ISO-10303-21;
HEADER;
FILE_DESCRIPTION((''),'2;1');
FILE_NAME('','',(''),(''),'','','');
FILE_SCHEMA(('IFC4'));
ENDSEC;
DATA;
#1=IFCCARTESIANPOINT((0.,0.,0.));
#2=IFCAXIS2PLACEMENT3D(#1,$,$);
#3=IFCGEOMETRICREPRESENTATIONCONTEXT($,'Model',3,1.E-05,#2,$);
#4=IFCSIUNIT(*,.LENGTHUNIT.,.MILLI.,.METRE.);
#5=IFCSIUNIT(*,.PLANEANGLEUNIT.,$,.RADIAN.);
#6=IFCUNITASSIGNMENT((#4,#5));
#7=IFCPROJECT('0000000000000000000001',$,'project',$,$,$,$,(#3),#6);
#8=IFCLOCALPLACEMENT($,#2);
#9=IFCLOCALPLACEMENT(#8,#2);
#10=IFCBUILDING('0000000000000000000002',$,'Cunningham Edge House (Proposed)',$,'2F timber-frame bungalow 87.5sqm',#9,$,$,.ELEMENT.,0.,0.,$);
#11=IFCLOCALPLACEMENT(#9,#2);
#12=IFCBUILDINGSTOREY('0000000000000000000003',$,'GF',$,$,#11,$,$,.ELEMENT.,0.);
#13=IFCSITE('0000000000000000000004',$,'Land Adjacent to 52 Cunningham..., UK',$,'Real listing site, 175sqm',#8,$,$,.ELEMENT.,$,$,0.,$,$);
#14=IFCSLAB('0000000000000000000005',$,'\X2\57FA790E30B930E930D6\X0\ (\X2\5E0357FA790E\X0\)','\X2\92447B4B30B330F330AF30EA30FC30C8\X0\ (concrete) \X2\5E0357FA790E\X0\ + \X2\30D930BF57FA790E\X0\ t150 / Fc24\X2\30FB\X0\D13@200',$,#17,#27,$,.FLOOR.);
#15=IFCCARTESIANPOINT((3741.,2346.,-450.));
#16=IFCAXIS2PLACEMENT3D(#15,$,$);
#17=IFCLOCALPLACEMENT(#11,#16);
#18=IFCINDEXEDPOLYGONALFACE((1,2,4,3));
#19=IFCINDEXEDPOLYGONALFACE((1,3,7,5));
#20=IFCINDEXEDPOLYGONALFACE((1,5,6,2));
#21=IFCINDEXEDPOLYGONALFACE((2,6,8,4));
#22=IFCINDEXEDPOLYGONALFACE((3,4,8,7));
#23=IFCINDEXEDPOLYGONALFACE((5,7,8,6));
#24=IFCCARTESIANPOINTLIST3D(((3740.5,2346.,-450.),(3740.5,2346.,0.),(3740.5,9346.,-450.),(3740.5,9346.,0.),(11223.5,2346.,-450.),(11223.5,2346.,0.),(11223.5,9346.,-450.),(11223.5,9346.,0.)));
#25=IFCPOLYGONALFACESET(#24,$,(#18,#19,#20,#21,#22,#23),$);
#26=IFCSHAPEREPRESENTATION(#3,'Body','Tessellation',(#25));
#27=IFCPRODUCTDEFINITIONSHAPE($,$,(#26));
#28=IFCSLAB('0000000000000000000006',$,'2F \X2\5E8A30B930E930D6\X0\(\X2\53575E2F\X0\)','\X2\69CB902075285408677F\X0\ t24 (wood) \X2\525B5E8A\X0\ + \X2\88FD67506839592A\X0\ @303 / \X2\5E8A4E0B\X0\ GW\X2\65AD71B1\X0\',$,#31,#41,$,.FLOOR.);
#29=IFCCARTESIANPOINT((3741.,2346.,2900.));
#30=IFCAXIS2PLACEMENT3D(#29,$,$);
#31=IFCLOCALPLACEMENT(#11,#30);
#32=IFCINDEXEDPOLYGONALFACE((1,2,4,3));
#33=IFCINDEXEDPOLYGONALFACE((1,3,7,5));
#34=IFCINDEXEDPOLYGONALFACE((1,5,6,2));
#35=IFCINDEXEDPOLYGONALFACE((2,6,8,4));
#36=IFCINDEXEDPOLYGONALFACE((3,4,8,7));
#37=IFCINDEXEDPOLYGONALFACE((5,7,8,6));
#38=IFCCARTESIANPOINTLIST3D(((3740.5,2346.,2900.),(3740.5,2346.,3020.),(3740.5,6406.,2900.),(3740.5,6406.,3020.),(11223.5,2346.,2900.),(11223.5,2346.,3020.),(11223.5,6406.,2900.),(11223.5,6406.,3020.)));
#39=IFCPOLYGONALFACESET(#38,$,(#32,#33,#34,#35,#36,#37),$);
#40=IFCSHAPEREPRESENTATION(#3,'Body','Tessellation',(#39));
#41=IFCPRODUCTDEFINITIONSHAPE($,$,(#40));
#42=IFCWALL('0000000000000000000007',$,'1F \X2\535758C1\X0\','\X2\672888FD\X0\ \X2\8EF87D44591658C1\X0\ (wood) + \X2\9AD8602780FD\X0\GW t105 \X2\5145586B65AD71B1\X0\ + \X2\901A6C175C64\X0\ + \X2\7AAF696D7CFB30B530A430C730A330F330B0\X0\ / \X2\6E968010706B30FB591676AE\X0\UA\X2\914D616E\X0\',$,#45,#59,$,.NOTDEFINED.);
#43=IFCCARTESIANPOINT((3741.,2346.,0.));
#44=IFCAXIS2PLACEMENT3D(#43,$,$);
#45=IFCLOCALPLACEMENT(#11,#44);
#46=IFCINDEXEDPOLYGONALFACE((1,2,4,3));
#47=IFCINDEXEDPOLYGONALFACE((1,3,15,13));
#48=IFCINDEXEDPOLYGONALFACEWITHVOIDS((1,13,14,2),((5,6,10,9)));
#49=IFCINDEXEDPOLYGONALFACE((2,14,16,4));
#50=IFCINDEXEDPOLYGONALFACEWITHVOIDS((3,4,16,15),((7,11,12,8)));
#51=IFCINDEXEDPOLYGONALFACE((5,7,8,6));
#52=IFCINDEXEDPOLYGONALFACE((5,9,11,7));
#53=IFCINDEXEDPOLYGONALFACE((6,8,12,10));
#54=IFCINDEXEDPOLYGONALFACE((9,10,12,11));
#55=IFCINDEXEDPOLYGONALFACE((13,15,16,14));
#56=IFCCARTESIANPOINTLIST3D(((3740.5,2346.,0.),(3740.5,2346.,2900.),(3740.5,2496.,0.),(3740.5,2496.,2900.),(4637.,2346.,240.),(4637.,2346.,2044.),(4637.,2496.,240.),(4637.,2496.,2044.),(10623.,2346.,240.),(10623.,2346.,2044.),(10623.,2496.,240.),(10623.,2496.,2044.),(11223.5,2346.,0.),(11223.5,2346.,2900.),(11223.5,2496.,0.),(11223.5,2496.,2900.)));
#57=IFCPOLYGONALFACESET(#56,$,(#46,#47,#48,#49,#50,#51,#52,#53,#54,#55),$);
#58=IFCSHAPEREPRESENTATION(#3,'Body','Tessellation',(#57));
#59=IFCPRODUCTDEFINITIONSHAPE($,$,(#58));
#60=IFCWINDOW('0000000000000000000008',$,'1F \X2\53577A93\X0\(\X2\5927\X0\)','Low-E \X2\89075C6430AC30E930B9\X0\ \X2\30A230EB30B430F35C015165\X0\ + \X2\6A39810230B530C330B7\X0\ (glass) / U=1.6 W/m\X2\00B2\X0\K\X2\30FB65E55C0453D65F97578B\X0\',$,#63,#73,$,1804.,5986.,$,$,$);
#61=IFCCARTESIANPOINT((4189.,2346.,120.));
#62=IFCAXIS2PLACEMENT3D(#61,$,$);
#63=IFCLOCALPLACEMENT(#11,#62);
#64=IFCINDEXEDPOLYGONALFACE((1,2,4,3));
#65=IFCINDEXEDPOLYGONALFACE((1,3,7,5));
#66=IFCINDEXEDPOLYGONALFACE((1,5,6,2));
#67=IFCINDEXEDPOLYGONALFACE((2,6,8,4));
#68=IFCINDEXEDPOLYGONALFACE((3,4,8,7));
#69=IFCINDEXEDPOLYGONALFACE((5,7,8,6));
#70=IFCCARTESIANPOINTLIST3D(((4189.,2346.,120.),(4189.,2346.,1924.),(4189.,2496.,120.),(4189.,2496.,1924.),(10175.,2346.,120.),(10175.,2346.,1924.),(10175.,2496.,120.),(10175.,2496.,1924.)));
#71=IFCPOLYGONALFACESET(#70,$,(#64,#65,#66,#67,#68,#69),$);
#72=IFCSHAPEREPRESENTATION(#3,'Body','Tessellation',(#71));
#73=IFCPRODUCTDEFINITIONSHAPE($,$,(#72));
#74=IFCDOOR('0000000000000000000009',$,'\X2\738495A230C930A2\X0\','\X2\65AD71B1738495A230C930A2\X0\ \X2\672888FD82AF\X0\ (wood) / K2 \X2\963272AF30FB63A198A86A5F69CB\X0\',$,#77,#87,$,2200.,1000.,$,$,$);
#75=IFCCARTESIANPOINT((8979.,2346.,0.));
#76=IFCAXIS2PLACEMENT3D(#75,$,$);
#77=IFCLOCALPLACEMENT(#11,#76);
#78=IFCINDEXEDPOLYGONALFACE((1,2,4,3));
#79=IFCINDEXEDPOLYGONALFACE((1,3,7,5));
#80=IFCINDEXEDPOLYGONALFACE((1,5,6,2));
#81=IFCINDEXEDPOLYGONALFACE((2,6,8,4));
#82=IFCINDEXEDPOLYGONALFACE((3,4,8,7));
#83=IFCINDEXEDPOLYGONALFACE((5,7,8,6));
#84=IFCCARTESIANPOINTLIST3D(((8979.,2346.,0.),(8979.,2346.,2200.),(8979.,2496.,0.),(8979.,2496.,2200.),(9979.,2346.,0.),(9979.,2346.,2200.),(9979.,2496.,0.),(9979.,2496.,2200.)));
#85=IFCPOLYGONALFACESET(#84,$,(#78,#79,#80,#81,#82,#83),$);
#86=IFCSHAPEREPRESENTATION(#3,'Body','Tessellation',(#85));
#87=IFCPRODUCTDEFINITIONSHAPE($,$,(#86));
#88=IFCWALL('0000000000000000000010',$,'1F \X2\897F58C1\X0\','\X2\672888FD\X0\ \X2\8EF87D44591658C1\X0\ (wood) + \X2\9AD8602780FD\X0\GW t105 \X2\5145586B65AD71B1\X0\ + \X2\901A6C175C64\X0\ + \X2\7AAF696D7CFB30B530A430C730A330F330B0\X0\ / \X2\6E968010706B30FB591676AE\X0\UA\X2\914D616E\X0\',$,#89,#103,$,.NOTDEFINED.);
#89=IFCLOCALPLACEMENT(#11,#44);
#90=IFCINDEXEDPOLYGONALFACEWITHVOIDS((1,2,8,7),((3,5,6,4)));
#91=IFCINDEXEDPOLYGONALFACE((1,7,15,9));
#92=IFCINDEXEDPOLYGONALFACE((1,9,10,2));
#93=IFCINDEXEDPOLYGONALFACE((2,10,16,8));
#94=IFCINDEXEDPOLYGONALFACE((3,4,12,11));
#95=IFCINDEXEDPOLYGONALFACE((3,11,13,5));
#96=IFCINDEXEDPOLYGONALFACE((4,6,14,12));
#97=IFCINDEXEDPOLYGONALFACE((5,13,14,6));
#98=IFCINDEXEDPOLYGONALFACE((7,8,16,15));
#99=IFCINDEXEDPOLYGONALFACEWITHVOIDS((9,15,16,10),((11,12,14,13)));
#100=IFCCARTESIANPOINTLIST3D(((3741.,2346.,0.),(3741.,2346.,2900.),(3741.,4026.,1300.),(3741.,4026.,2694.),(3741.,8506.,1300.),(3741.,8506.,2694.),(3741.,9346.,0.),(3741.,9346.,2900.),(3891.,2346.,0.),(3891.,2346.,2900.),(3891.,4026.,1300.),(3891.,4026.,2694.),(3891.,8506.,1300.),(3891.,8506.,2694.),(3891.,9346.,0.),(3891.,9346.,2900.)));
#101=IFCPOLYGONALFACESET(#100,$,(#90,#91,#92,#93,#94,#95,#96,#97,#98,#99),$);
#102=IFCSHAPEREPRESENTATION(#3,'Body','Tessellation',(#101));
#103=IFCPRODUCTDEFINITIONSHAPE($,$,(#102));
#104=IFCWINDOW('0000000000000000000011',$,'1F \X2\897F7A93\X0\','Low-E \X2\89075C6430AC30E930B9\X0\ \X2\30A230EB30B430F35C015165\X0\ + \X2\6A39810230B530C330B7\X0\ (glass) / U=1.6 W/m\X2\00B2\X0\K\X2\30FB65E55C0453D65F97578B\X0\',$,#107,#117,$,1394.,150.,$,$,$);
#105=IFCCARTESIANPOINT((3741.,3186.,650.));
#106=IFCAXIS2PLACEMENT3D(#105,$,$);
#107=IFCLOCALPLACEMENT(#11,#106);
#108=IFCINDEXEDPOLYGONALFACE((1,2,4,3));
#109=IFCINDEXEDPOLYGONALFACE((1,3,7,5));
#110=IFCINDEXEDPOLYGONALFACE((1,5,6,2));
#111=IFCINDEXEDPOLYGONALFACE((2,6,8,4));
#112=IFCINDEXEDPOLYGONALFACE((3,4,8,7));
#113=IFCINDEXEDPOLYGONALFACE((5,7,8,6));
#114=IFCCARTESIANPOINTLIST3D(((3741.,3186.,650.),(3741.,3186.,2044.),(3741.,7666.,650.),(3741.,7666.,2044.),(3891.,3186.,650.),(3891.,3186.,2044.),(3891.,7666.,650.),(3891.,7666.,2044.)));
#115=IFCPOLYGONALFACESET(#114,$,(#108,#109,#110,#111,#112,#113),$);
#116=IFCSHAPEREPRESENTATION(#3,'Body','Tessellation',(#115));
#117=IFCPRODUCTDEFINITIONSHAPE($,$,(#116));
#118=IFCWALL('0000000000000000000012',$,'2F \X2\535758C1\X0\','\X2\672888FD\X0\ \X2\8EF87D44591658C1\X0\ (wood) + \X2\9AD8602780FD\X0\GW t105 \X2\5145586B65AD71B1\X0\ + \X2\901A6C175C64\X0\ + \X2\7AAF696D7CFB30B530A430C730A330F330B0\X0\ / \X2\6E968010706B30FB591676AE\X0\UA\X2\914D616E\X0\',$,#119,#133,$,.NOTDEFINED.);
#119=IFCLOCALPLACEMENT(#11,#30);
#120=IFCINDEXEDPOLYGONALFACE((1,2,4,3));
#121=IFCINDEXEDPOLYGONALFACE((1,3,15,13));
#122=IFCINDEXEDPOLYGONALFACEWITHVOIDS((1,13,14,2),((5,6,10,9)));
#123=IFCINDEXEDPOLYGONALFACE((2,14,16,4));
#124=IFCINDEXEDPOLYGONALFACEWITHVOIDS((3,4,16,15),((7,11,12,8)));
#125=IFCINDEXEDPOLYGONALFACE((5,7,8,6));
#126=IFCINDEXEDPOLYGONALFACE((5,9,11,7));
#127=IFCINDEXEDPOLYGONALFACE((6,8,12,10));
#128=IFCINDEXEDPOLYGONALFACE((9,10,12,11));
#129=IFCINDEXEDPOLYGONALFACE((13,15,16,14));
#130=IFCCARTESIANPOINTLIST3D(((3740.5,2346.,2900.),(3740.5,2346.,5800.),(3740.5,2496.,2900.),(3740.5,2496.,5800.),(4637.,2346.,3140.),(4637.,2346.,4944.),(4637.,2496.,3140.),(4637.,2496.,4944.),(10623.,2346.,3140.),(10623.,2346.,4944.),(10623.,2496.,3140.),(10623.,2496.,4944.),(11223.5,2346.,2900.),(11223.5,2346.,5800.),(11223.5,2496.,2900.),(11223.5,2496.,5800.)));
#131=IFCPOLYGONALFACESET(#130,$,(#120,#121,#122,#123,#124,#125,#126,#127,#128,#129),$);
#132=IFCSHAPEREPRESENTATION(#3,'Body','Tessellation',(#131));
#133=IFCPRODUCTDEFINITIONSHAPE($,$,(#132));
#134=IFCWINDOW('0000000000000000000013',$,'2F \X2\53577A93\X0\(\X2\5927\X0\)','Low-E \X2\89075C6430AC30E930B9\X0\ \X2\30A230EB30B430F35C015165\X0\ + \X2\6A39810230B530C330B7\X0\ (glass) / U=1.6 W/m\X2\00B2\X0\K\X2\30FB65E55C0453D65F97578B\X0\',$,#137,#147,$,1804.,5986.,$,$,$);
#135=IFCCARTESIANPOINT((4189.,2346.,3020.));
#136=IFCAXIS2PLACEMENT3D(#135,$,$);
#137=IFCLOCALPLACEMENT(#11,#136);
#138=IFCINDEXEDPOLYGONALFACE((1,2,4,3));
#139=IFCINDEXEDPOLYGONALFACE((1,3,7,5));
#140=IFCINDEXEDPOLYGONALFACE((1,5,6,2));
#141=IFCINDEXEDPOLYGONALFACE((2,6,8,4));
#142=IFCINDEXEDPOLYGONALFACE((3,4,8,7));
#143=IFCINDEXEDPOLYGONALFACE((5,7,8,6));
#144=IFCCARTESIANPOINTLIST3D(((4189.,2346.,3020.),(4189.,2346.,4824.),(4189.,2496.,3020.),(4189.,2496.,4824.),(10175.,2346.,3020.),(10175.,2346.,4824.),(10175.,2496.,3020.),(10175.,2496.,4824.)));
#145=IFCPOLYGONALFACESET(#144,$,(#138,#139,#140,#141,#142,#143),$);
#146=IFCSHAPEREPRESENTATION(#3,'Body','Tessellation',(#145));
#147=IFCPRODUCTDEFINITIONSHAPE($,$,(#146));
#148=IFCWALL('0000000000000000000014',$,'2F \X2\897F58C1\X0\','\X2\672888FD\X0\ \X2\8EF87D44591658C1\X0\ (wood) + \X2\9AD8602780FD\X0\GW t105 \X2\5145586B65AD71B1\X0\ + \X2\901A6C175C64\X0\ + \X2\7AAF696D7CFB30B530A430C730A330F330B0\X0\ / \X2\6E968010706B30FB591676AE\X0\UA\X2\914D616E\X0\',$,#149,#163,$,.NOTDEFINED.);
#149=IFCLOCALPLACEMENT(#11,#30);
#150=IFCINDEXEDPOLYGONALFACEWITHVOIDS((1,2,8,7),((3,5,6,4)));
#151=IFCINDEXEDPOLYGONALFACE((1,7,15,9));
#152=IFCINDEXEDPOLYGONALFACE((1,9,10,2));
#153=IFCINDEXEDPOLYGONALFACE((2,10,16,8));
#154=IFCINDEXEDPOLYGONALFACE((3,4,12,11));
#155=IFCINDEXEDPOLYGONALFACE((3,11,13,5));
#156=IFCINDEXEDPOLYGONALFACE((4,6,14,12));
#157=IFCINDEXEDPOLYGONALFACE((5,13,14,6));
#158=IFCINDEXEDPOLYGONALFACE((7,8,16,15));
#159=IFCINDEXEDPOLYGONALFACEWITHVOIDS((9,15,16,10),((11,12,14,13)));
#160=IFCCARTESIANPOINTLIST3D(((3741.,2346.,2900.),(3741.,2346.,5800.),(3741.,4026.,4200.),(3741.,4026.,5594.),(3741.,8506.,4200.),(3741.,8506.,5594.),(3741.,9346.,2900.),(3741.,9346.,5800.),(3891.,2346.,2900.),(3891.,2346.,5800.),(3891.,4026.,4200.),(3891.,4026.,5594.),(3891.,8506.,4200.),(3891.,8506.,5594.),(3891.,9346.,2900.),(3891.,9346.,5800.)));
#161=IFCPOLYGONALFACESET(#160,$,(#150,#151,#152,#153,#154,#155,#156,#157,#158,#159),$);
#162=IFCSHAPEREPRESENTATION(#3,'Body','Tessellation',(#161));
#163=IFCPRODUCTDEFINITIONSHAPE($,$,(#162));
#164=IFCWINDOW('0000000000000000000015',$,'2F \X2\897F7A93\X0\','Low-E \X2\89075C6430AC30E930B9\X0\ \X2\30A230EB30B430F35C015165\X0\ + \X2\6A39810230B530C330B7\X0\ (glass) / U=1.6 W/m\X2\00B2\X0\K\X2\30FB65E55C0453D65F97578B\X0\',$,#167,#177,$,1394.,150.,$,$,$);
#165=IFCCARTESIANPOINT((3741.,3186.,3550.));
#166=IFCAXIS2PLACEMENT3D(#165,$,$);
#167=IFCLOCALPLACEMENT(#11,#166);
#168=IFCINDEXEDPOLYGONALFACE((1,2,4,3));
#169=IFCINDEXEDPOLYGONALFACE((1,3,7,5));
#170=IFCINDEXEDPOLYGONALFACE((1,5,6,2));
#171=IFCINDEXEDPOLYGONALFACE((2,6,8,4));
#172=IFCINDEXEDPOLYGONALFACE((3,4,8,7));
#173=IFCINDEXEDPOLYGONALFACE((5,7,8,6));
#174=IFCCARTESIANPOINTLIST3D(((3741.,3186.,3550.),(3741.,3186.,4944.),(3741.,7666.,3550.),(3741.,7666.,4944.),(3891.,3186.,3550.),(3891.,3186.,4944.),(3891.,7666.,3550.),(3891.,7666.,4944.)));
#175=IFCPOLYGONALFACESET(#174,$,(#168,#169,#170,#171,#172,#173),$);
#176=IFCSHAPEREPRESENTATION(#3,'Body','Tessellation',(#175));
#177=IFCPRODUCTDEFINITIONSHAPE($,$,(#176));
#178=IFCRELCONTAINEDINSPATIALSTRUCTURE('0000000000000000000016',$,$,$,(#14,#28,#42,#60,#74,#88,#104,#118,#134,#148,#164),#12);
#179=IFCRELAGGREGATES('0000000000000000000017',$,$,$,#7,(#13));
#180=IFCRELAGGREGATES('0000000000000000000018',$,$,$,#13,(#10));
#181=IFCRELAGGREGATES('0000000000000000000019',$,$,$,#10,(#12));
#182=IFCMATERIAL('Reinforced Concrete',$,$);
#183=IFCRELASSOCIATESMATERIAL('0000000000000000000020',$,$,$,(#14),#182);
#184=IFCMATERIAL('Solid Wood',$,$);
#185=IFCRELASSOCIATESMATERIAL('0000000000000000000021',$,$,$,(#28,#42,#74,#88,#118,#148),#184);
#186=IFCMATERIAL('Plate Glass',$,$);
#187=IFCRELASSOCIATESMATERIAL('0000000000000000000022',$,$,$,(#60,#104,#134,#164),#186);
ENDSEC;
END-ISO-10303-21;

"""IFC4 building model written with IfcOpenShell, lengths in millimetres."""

from ifc_helpers import new_model, si_unit, frame, frame_2d, origin, place, context, project, spatial, rectangle, extrude, material, element, fill, save


model = new_model("IFC4")

# Units and contexts
model_context = context("Model", 3, precision=1e-05, world=origin())
ifc_project = project(units=[si_unit("LENGTHUNIT", "METRE", prefix="MILLI"), si_unit("PLANEANGLEUNIT", "RADIAN")], contexts=[model_context])

# Site, building, storey
site_placement = place(None, origin())
site = spatial("IfcSite", under=ifc_project, at=site_placement, Name="Land Adjacent to 52 Cunningham..., UK", ObjectType="Real listing site, 175sqm", CompositionType="ELEMENT", RefElevation=0.0)
building_placement = place(site_placement, origin())
building = spatial("IfcBuilding", under=site, at=building_placement, Name="Cunningham Edge House (Proposed)", ObjectType="2F timber-frame bungalow 87.5sqm", CompositionType="ELEMENT", ElevationOfRefHeight=0.0, ElevationOfTerrain=0.0)
storey_placement = place(building_placement, origin())
storey = spatial("IfcBuildingStorey", under=building, at=storey_placement, Name="GF", CompositionType="ELEMENT", Elevation=0.0)

# Slabs
ifc_material_1 = material(Name="Reinforced Concrete")
slab_1_placement = place(storey_placement, frame((3741.0, 2346.0, -450.0)))
element("IfcSlab", 1, at=slab_1_placement, inside=storey, material=ifc_material_1, Name="基礎スラブ (布基礎)", Description="鉄筋コンクリート (concrete) 布基礎 + ベタ基礎 t150 / Fc24・D13@200", PredefinedType="FLOOR", context=model_context, shape_type="SweptSolid", body=[
    extrude(rectangle(XDim=7483.0, YDim=7000.0, at=frame_2d((3741.0, 3500.0))), frame((3741.0, 2346.0, -450.0)), (0.0, 0.0, 1.0), 450.0),
])
ifc_material_2 = material(Name="Solid Wood")
slab_2_placement = place(storey_placement, frame((3741.0, 2346.0, 2900.0)))
element("IfcSlab", 2, at=slab_2_placement, inside=storey, material=ifc_material_2, Name="2F 床スラブ(南帯)", Description="構造用合板 t24 (wood) 剛床 + 製材根太 @303 / 床下 GW断熱", PredefinedType="FLOOR", context=model_context, shape_type="SweptSolid", body=[
    extrude(rectangle(XDim=7483.0, YDim=4060.0, at=frame_2d((3741.0, 2030.0))), frame((3741.0, 2346.0, 2900.0)), (0.0, 0.0, 1.0), 120.0),
])

# Wall, openings, window, door
wall_1_placement = place(storey_placement, frame((3741.0, 2346.0, 0.0)))
wall_1 = element("IfcWall", 3, at=wall_1_placement, inside=storey, material=ifc_material_2, Name="1F 南壁", Description="木製 軸組外壁 (wood) + 高性能GW t105 充填断熱 + 通気層 + 窯業系サイディング / 準耐火・外皮UA配慮", PredefinedType="NOTDEFINED", context=model_context, shape_type="SweptSolid", body=[
    extrude(rectangle(XDim=7483.0, YDim=150.0, at=frame_2d((3741.0, 75.0))), frame((3741.0, 2346.0, 0.0)), (0.0, 0.0, 1.0), 2900.0),
])
opening_1_placement = place(storey_placement, frame((4189.0, 2346.0, 120.0)))
opening_1 = element("IfcOpeningElement", 4, at=opening_1_placement, cuts=wall_1, PredefinedType="NOTDEFINED", context=model_context, shape_type="SweptSolid", body=[
    extrude(rectangle(XDim=5986.0, YDim=150.0, at=frame_2d((2993.0, 75.0))), frame((4189.0, 2346.0, 120.0)), (0.0, 0.0, 1.0), 1804.0),
])
opening_2_placement = place(storey_placement, frame((8979.0, 2346.0, 0.0)))
opening_2 = element("IfcOpeningElement", 5, at=opening_2_placement, cuts=wall_1, PredefinedType="NOTDEFINED", context=model_context, shape_type="SweptSolid", body=[
    extrude(rectangle(XDim=1000.0, YDim=150.0, at=frame_2d((500.0, 75.0))), frame((8979.0, 2346.0, 0.0)), (0.0, 0.0, 1.0), 2200.0),
])
ifc_material_3 = material(Name="Plate Glass")
window_1_placement = place(storey_placement, frame((4189.0, 2346.0, 120.0)))
window_1 = element("IfcWindow", 6, at=window_1_placement, inside=storey, material=ifc_material_3, Name="1F 南窓(大)", Description="Low-E 複層ガラス アルゴン封入 + 樹脂サッシ (glass) / U=1.6 W/m²K・日射取得型", OverallHeight=1804.0, OverallWidth=5986.0, context=model_context, shape_type="SweptSolid", body=[
    extrude(rectangle(XDim=5986.0, YDim=150.0, at=frame_2d((2993.0, 75.0))), frame((4189.0, 2346.0, 120.0)), (0.0, 0.0, 1.0), 1804.0),
])
fill(opening_1, window_1)
door_placement = place(storey_placement, frame((8979.0, 2346.0, 0.0)))
door = element("IfcDoor", 7, at=door_placement, inside=storey, material=ifc_material_2, Name="玄関ドア", Description="断熱玄関ドア 木製芯 (wood) / K2 防犯・採風機構", OverallHeight=2200.0, OverallWidth=1000.0, context=model_context, shape_type="SweptSolid", body=[
    extrude(rectangle(XDim=1000.0, YDim=150.0, at=frame_2d((500.0, 75.0))), frame((8979.0, 2346.0, 0.0)), (0.0, 0.0, 1.0), 2200.0),
])
fill(opening_2, door)

# Wall, opening, window
wall_2_placement = place(storey_placement, frame((3741.0, 2346.0, 0.0)))
wall_2 = element("IfcWall", 8, at=wall_2_placement, inside=storey, material=ifc_material_2, Name="1F 西壁", Description="木製 軸組外壁 (wood) + 高性能GW t105 充填断熱 + 通気層 + 窯業系サイディング / 準耐火・外皮UA配慮", PredefinedType="NOTDEFINED", context=model_context, shape_type="SweptSolid", body=[
    extrude(rectangle(XDim=150.0, YDim=7000.0, at=frame_2d((75.0, 3500.0))), frame((3741.0, 2346.0, 0.0)), (0.0, 0.0, 1.0), 2900.0),
])
opening_3_placement = place(storey_placement, frame((3741.0, 3186.0, 650.0)))
opening_3 = element("IfcOpeningElement", 9, at=opening_3_placement, cuts=wall_2, PredefinedType="NOTDEFINED", context=model_context, shape_type="SweptSolid", body=[
    extrude(rectangle(XDim=150.0, YDim=4480.0, at=frame_2d((75.0, 2240.0))), frame((3741.0, 3186.0, 650.0)), (0.0, 0.0, 1.0), 1394.0),
])
window_2_placement = place(storey_placement, frame((3741.0, 3186.0, 650.0)))
window_2 = element("IfcWindow", 10, at=window_2_placement, inside=storey, material=ifc_material_3, Name="1F 西窓", Description="Low-E 複層ガラス アルゴン封入 + 樹脂サッシ (glass) / U=1.6 W/m²K・日射取得型", OverallHeight=1394.0, OverallWidth=150.0, context=model_context, shape_type="SweptSolid", body=[
    extrude(rectangle(XDim=150.0, YDim=4480.0, at=frame_2d((75.0, 2240.0))), frame((3741.0, 3186.0, 650.0)), (0.0, 0.0, 1.0), 1394.0),
])
fill(opening_3, window_2)

# Walls, openings, windows
wall_3_placement = place(storey_placement, frame((3741.0, 2346.0, 2900.0)))
wall_3 = element("IfcWall", 11, at=wall_3_placement, inside=storey, material=ifc_material_2, Name="2F 南壁", Description="木製 軸組外壁 (wood) + 高性能GW t105 充填断熱 + 通気層 + 窯業系サイディング / 準耐火・外皮UA配慮", PredefinedType="NOTDEFINED", context=model_context, shape_type="SweptSolid", body=[
    extrude(rectangle(XDim=7483.0, YDim=150.0, at=frame_2d((3741.0, 75.0))), frame((3741.0, 2346.0, 2900.0)), (0.0, 0.0, 1.0), 2900.0),
])
opening_4_placement = place(storey_placement, frame((4189.0, 2346.0, 3020.0)))
opening_4 = element("IfcOpeningElement", 12, at=opening_4_placement, cuts=wall_3, PredefinedType="NOTDEFINED", context=model_context, shape_type="SweptSolid", body=[
    extrude(rectangle(XDim=5986.0, YDim=150.0, at=frame_2d((2993.0, 75.0))), frame((4189.0, 2346.0, 3020.0)), (0.0, 0.0, 1.0), 1804.0),
])
window_3_placement = place(storey_placement, frame((4189.0, 2346.0, 3020.0)))
window_3 = element("IfcWindow", 13, at=window_3_placement, inside=storey, material=ifc_material_3, Name="2F 南窓(大)", Description="Low-E 複層ガラス アルゴン封入 + 樹脂サッシ (glass) / U=1.6 W/m²K・日射取得型", OverallHeight=1804.0, OverallWidth=5986.0, context=model_context, shape_type="SweptSolid", body=[
    extrude(rectangle(XDim=5986.0, YDim=150.0, at=frame_2d((2993.0, 75.0))), frame((4189.0, 2346.0, 3020.0)), (0.0, 0.0, 1.0), 1804.0),
])
fill(opening_4, window_3)
wall_4_placement = place(storey_placement, frame((3741.0, 2346.0, 2900.0)))
wall_4 = element("IfcWall", 14, at=wall_4_placement, inside=storey, material=ifc_material_2, Name="2F 西壁", Description="木製 軸組外壁 (wood) + 高性能GW t105 充填断熱 + 通気層 + 窯業系サイディング / 準耐火・外皮UA配慮", PredefinedType="NOTDEFINED", context=model_context, shape_type="SweptSolid", body=[
    extrude(rectangle(XDim=150.0, YDim=7000.0, at=frame_2d((75.0, 3500.0))), frame((3741.0, 2346.0, 2900.0)), (0.0, 0.0, 1.0), 2900.0),
])
opening_5_placement = place(storey_placement, frame((3741.0, 3186.0, 3550.0)))
opening_5 = element("IfcOpeningElement", 15, at=opening_5_placement, cuts=wall_4, PredefinedType="NOTDEFINED", context=model_context, shape_type="SweptSolid", body=[
    extrude(rectangle(XDim=150.0, YDim=4480.0, at=frame_2d((75.0, 2240.0))), frame((3741.0, 3186.0, 3550.0)), (0.0, 0.0, 1.0), 1394.0),
])
window_4_placement = place(storey_placement, frame((3741.0, 3186.0, 3550.0)))
window_4 = element("IfcWindow", 16, at=window_4_placement, inside=storey, material=ifc_material_3, Name="2F 西窓", Description="Low-E 複層ガラス アルゴン封入 + 樹脂サッシ (glass) / U=1.6 W/m²K・日射取得型", OverallHeight=1394.0, OverallWidth=150.0, context=model_context, shape_type="SweptSolid", body=[
    extrude(rectangle(XDim=150.0, YDim=4480.0, at=frame_2d((75.0, 2240.0))), frame((3741.0, 3186.0, 3550.0)), (0.0, 0.0, 1.0), 1394.0),
])
fill(opening_5, window_4)

save(model, "model.ifc")
